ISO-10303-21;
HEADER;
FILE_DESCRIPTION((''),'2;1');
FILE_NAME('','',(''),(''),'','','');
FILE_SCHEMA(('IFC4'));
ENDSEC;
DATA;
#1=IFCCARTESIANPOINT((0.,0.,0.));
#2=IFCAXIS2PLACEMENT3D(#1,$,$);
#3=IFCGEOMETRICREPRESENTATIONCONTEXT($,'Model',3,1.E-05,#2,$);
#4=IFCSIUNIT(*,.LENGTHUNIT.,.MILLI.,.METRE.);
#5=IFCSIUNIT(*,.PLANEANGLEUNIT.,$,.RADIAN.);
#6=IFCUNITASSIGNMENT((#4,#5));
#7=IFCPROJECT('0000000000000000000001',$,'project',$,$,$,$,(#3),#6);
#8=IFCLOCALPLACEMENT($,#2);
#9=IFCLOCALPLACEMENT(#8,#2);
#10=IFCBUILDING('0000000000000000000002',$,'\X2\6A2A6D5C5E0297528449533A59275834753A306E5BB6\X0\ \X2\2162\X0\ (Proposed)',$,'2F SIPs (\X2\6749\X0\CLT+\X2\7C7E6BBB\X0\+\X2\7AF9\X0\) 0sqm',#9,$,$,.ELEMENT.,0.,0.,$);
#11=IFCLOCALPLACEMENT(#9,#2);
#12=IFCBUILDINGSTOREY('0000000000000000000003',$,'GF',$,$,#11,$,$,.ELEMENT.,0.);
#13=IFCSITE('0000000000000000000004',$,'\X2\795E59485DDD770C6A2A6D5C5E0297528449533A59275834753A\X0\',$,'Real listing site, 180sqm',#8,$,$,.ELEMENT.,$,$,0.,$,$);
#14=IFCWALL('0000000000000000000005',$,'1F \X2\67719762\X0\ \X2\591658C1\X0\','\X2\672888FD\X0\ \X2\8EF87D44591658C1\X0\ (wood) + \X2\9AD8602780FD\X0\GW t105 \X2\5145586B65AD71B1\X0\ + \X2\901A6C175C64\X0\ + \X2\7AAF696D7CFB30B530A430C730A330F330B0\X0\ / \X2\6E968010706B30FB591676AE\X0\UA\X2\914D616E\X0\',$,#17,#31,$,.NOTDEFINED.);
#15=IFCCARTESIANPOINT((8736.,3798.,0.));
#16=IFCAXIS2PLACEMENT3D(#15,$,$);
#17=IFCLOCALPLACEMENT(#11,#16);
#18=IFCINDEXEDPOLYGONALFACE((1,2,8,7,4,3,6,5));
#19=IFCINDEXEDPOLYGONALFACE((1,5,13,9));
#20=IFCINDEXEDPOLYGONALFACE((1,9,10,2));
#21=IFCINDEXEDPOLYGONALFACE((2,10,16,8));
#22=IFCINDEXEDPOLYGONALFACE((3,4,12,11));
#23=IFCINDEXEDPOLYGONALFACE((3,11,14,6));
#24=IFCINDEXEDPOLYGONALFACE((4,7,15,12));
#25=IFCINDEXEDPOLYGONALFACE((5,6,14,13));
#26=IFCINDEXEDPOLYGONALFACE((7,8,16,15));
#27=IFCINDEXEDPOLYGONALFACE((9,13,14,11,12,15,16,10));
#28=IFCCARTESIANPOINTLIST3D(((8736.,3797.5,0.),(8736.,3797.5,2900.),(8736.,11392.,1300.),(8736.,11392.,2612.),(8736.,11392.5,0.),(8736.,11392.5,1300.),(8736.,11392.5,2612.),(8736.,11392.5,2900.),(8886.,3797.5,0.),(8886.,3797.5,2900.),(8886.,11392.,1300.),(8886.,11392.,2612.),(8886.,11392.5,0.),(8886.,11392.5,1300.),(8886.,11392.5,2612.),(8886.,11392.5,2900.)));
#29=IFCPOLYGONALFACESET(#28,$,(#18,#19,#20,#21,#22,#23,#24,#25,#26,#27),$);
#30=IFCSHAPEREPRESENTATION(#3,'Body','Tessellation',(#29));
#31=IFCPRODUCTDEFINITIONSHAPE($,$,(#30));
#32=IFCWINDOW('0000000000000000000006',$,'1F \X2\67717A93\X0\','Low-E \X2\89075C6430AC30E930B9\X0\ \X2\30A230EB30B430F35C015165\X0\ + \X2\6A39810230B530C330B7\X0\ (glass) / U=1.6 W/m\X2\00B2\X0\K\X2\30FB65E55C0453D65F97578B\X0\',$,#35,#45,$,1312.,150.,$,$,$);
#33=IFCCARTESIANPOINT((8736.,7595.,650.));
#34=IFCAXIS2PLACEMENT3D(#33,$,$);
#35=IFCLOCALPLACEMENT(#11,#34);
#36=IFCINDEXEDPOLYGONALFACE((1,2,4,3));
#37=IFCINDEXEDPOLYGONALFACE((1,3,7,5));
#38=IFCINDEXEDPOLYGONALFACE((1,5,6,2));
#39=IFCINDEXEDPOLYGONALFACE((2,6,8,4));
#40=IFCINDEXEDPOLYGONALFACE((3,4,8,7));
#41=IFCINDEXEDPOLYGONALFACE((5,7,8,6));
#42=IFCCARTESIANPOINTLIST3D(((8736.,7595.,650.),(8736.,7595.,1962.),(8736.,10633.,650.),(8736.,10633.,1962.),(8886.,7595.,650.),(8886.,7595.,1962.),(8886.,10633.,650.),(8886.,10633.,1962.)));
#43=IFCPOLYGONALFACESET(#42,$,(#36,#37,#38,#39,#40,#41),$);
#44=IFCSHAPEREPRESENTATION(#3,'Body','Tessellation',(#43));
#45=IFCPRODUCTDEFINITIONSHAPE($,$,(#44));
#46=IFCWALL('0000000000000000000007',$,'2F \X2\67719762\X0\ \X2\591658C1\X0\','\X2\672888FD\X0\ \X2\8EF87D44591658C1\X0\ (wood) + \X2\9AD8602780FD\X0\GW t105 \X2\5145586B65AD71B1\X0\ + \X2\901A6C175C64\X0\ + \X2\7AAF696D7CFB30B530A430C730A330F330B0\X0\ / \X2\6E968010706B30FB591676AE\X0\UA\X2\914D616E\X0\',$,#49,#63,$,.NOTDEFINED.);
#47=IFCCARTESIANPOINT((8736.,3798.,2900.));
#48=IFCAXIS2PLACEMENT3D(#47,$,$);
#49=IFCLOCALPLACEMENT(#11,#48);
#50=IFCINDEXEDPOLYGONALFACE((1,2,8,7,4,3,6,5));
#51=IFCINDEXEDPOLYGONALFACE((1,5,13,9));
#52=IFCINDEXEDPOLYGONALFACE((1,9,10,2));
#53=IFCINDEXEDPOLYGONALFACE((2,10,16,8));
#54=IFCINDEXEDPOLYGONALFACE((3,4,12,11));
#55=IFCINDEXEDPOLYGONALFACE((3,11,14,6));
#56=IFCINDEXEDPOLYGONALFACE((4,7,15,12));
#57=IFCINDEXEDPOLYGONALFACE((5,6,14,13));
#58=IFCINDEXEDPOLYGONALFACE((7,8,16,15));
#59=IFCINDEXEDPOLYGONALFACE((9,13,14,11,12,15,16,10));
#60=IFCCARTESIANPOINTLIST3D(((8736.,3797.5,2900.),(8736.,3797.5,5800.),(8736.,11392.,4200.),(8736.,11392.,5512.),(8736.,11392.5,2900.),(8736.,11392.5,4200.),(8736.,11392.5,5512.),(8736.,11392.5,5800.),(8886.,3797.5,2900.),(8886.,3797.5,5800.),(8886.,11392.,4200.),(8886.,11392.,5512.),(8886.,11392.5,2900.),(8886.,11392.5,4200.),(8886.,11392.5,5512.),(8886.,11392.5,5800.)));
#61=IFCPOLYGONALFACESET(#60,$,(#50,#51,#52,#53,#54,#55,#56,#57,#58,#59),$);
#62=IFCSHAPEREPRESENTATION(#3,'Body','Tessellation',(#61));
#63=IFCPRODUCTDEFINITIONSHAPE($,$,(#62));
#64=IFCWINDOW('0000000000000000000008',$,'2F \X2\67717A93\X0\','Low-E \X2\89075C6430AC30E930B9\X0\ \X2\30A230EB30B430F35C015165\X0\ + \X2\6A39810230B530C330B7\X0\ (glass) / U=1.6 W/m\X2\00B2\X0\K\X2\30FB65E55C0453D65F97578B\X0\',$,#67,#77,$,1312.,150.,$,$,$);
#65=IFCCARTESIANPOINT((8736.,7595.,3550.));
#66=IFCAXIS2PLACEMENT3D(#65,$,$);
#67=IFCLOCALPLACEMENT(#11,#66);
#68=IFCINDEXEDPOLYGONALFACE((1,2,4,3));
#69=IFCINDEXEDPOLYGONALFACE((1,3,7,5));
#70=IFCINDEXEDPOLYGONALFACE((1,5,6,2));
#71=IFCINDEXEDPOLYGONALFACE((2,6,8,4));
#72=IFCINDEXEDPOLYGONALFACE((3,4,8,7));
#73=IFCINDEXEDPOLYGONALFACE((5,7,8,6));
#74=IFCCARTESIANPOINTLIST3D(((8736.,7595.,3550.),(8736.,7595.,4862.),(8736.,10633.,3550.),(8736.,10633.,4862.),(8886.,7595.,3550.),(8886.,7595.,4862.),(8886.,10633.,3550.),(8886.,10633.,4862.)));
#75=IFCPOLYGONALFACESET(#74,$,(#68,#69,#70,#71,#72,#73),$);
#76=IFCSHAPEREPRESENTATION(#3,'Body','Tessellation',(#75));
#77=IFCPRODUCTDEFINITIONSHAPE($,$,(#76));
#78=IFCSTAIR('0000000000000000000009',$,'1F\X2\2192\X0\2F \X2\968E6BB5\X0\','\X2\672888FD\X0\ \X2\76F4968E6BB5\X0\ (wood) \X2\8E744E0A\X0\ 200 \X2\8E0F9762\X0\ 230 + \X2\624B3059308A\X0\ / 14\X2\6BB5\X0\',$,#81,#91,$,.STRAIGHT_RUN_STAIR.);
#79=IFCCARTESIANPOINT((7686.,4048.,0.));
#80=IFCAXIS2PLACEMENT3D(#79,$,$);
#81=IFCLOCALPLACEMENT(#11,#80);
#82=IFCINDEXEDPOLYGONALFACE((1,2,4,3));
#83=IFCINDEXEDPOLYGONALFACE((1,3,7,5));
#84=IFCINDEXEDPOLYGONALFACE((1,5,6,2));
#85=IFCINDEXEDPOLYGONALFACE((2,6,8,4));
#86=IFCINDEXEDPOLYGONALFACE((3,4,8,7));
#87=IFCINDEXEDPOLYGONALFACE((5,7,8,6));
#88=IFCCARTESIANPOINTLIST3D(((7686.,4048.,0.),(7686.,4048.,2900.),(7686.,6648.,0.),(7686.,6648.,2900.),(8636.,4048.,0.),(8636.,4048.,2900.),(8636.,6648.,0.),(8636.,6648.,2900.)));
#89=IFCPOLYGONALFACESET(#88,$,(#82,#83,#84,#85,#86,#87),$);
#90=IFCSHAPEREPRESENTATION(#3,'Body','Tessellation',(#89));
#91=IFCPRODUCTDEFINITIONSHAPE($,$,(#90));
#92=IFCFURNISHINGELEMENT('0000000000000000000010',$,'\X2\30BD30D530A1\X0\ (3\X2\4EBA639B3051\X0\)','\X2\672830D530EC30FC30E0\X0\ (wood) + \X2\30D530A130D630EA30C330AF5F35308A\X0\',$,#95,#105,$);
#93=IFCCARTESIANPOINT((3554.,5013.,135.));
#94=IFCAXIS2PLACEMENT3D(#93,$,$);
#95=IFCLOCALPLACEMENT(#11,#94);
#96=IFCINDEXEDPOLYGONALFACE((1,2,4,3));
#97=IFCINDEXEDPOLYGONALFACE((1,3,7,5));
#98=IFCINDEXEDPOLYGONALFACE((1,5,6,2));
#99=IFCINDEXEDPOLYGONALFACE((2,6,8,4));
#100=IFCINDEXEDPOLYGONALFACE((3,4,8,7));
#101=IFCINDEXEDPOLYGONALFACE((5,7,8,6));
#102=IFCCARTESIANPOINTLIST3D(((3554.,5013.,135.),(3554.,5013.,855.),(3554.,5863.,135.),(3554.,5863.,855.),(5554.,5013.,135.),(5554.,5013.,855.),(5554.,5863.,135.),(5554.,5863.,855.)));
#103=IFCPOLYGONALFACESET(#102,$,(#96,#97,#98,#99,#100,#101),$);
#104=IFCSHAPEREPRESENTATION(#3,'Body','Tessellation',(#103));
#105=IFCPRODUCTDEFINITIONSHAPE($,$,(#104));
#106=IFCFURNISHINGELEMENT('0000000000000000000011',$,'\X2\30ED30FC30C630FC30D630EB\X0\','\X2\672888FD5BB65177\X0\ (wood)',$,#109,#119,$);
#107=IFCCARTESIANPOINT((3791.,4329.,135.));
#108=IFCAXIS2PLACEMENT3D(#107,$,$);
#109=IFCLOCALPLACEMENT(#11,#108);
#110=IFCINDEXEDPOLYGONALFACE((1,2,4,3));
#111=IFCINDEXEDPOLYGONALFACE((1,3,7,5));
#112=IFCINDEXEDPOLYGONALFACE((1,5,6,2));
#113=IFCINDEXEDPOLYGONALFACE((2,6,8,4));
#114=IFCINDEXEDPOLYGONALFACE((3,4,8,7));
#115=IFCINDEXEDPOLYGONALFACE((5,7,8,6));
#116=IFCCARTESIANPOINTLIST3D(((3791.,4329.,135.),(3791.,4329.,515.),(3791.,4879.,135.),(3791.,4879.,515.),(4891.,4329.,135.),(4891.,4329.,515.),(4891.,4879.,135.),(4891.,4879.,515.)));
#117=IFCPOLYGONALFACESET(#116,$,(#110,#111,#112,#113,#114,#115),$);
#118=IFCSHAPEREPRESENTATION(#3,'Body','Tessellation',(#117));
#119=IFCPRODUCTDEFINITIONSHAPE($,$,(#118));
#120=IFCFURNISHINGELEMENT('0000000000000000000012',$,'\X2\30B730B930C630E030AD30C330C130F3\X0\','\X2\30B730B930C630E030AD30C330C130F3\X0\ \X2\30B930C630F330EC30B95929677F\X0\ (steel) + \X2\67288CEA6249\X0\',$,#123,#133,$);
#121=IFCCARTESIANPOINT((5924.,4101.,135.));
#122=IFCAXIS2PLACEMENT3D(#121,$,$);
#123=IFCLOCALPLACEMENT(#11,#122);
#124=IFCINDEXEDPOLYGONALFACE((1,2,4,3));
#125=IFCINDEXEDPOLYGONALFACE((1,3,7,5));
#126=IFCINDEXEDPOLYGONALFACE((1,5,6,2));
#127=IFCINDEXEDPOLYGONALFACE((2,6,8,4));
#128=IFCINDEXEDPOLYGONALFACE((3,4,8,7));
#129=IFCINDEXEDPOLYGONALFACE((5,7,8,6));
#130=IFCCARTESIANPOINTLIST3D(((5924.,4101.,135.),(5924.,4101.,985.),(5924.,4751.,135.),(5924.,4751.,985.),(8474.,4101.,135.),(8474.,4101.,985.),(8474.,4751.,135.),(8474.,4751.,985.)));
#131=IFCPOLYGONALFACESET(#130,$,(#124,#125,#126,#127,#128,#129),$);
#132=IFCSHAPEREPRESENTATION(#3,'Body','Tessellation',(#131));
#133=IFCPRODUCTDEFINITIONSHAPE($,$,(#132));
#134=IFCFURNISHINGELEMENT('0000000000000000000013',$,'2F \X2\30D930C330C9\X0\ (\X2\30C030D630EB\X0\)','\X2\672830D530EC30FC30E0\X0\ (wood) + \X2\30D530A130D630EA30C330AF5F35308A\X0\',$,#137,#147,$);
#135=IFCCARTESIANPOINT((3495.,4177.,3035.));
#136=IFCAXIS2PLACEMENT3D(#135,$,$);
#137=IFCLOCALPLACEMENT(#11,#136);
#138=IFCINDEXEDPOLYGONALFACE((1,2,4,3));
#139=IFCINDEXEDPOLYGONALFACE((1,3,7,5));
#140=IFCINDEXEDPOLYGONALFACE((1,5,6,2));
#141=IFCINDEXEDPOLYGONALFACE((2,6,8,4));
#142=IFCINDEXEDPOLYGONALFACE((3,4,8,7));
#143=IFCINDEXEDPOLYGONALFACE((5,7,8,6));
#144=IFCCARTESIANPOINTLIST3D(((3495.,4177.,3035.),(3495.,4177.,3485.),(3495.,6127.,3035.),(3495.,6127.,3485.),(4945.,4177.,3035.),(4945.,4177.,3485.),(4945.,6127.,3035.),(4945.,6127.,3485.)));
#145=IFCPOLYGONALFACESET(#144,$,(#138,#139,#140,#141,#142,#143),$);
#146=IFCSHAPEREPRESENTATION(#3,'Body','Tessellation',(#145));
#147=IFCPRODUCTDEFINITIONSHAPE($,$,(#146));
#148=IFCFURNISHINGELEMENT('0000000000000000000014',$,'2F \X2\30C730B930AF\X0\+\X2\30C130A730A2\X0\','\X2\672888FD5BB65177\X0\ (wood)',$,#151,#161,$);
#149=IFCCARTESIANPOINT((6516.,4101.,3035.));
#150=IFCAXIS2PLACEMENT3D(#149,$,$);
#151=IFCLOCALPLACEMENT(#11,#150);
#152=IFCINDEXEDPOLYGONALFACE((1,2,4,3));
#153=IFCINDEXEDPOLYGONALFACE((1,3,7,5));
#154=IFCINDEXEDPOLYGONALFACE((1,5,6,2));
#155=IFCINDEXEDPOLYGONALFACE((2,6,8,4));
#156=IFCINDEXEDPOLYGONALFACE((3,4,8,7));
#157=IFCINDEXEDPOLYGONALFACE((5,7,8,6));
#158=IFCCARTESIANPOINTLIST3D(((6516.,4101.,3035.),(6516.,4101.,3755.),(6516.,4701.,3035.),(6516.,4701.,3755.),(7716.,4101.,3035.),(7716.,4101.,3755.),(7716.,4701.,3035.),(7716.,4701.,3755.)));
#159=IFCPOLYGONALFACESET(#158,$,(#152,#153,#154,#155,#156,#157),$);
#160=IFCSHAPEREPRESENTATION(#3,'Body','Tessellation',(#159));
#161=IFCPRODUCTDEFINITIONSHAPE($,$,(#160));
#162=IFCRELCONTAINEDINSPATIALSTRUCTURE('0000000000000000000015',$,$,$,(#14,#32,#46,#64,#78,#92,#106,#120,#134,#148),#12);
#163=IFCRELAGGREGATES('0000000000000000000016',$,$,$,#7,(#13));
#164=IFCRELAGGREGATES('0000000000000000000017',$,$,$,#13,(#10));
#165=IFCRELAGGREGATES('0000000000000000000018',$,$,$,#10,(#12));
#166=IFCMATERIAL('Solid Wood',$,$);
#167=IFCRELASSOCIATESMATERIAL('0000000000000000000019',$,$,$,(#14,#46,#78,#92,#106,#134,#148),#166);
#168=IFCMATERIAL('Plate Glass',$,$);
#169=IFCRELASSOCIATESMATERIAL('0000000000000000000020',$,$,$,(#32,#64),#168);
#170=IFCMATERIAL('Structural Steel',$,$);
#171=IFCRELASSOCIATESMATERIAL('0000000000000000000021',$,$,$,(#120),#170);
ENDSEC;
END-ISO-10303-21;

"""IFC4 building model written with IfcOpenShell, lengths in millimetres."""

from ifc_helpers import new_model, si_unit, frame, frame_2d, origin, place, context, project, spatial, rectangle, extrude, material, element, fill, save


model = new_model("IFC4")

# Units and contexts
model_context = context("Model", 3, precision=1e-05, world=origin())
ifc_project = project(units=[si_unit("LENGTHUNIT", "METRE", prefix="MILLI"), si_unit("PLANEANGLEUNIT", "RADIAN")], contexts=[model_context])

# Site, building, storey
site_placement = place(None, origin())
site = spatial("IfcSite", under=ifc_project, at=site_placement, Name="神奈川県横浜市青葉区大場町", ObjectType="Real listing site, 180sqm", CompositionType="ELEMENT", RefElevation=0.0)
building_placement = place(site_placement, origin())
building = spatial("IfcBuilding", under=site, at=building_placement, Name="横浜市青葉区大場町の家 Ⅲ (Proposed)", ObjectType="2F SIPs (杉CLT+籾殻+竹) 0sqm", CompositionType="ELEMENT", ElevationOfRefHeight=0.0, ElevationOfTerrain=0.0)
storey_placement = place(building_placement, origin())
storey = spatial("IfcBuildingStorey", under=building, at=storey_placement, Name="GF", CompositionType="ELEMENT", Elevation=0.0)

# Wall, opening, window
ifc_material_1 = material(Name="Solid Wood")
wall_1_placement = place(storey_placement, frame((8736.0, 3798.0, 0.0)))
wall_1 = element("IfcWall", 1, at=wall_1_placement, inside=storey, material=ifc_material_1, Name="1F 東面 外壁", Description="木製 軸組外壁 (wood) + 高性能GW t105 充填断熱 + 通気層 + 窯業系サイディング / 準耐火・外皮UA配慮", PredefinedType="NOTDEFINED", context=model_context, shape_type="SweptSolid", body=[
    extrude(rectangle(XDim=150.0, YDim=7595.0, at=frame_2d((75.0, 3797.0))), frame((8736.0, 3798.0, 0.0)), (0.0, 0.0, 1.0), 2900.0),
])
opening_1_placement = place(storey_placement, frame((8736.0, 7595.0, 650.0)))
opening_1 = element("IfcOpeningElement", 2, at=opening_1_placement, cuts=wall_1, PredefinedType="NOTDEFINED", context=model_context, shape_type="SweptSolid", body=[
    extrude(rectangle(XDim=150.0, YDim=3038.0, at=frame_2d((75.0, 1519.0))), frame((8736.0, 7595.0, 650.0)), (0.0, 0.0, 1.0), 1312.0),
])
ifc_material_2 = material(Name="Plate Glass")
window_1_placement = place(storey_placement, frame((8736.0, 7595.0, 650.0)))
window_1 = element("IfcWindow", 3, at=window_1_placement, inside=storey, material=ifc_material_2, Name="1F 東窓", Description="Low-E 複層ガラス アルゴン封入 + 樹脂サッシ (glass) / U=1.6 W/m²K・日射取得型", OverallHeight=1312.0, OverallWidth=150.0, context=model_context, shape_type="SweptSolid", body=[
    extrude(rectangle(XDim=150.0, YDim=3038.0, at=frame_2d((75.0, 1519.0))), frame((8736.0, 7595.0, 650.0)), (0.0, 0.0, 1.0), 1312.0),
])
fill(opening_1, window_1)

# Wall, opening, window
wall_2_placement = place(storey_placement, frame((8736.0, 3798.0, 2900.0)))
wall_2 = element("IfcWall", 4, at=wall_2_placement, inside=storey, material=ifc_material_1, Name="2F 東面 外壁", Description="木製 軸組外壁 (wood) + 高性能GW t105 充填断熱 + 通気層 + 窯業系サイディング / 準耐火・外皮UA配慮", PredefinedType="NOTDEFINED", context=model_context, shape_type="SweptSolid", body=[
    extrude(rectangle(XDim=150.0, YDim=7595.0, at=frame_2d((75.0, 3797.0))), frame((8736.0, 3798.0, 2900.0)), (0.0, 0.0, 1.0), 2900.0),
])
opening_2_placement = place(storey_placement, frame((8736.0, 7595.0, 3550.0)))
opening_2 = element("IfcOpeningElement", 5, at=opening_2_placement, cuts=wall_2, PredefinedType="NOTDEFINED", context=model_context, shape_type="SweptSolid", body=[
    extrude(rectangle(XDim=150.0, YDim=3038.0, at=frame_2d((75.0, 1519.0))), frame((8736.0, 7595.0, 3550.0)), (0.0, 0.0, 1.0), 1312.0),
])
window_2_placement = place(storey_placement, frame((8736.0, 7595.0, 3550.0)))
window_2 = element("IfcWindow", 6, at=window_2_placement, inside=storey, material=ifc_material_2, Name="2F 東窓", Description="Low-E 複層ガラス アルゴン封入 + 樹脂サッシ (glass) / U=1.6 W/m²K・日射取得型", OverallHeight=1312.0, OverallWidth=150.0, context=model_context, shape_type="SweptSolid", body=[
    extrude(rectangle(XDim=150.0, YDim=3038.0, at=frame_2d((75.0, 1519.0))), frame((8736.0, 7595.0, 3550.0)), (0.0, 0.0, 1.0), 1312.0),
])
fill(opening_2, window_2)

# Stair
stair_placement = place(storey_placement, frame((7686.0, 4048.0, 0.0)))
element("IfcStair", 7, at=stair_placement, inside=storey, material=ifc_material_1, Name="1F→2F 階段", Description="木製 直階段 (wood) 蹴上 200 踏面 230 + 手すり / 14段", PredefinedType="STRAIGHT_RUN_STAIR", context=model_context, shape_type="SweptSolid", body=[
    extrude(rectangle(XDim=950.0, YDim=2600.0, at=frame_2d((475.0, 1300.0))), frame((7686.0, 4048.0, 0.0)), (0.0, 0.0, 1.0), 2900.0),
])

# Furnishing elements
furnishing_1_placement = place(storey_placement, frame((3554.0, 5013.0, 135.0)))
element("IfcFurnishingElement", 8, at=furnishing_1_placement, inside=storey, material=ifc_material_1, Name="ソファ (3人掛け)", Description="木フレーム (wood) + ファブリック張り", context=model_context, shape_type="SweptSolid", body=[
    extrude(rectangle(XDim=2000.0, YDim=850.0, at=frame_2d((1000.0, 425.0))), frame((3554.0, 5013.0, 135.0)), (0.0, 0.0, 1.0), 720.0),
])
furnishing_2_placement = place(storey_placement, frame((3791.0, 4329.0, 135.0)))
element("IfcFurnishingElement", 9, at=furnishing_2_placement, inside=storey, material=ifc_material_1, Name="ローテーブル", Description="木製家具 (wood)", context=model_context, shape_type="SweptSolid", body=[
    extrude(rectangle(XDim=1100.0, YDim=550.0, at=frame_2d((550.0, 275.0))), frame((3791.0, 4329.0, 135.0)), (0.0, 0.0, 1.0), 380.0),
])
ifc_material_3 = material(Name="Structural Steel")
furnishing_3_placement = place(storey_placement, frame((5924.0, 4101.0, 135.0)))
element("IfcFurnishingElement", 10, at=furnishing_3_placement, inside=storey, material=ifc_material_3, Name="システムキッチン", Description="システムキッチン ステンレス天板 (steel) + 木質扉", context=model_context, shape_type="SweptSolid", body=[
    extrude(rectangle(XDim=2550.0, YDim=650.0, at=frame_2d((1275.0, 325.0))), frame((5924.0, 4101.0, 135.0)), (0.0, 0.0, 1.0), 850.0),
])
furnishing_4_placement = place(storey_placement, frame((3495.0, 4177.0, 3035.0)))
element("IfcFurnishingElement", 11, at=furnishing_4_placement, inside=storey, material=ifc_material_1, Name="2F ベッド (ダブル)", Description="木フレーム (wood) + ファブリック張り", context=model_context, shape_type="SweptSolid", body=[
    extrude(rectangle(XDim=1450.0, YDim=1950.0, at=frame_2d((725.0, 975.0))), frame((3495.0, 4177.0, 3035.0)), (0.0, 0.0, 1.0), 450.0),
])
furnishing_5_placement = place(storey_placement, frame((6516.0, 4101.0, 3035.0)))
element("IfcFurnishingElement", 12, at=furnishing_5_placement, inside=storey, material=ifc_material_1, Name="2F デスク+チェア", Description="木製家具 (wood)", context=model_context, shape_type="SweptSolid", body=[
    extrude(rectangle(XDim=1200.0, YDim=600.0, at=frame_2d((600.0, 300.0))), frame((6516.0, 4101.0, 3035.0)), (0.0, 0.0, 1.0), 720.0),
])

save(model, "model.ifc")
